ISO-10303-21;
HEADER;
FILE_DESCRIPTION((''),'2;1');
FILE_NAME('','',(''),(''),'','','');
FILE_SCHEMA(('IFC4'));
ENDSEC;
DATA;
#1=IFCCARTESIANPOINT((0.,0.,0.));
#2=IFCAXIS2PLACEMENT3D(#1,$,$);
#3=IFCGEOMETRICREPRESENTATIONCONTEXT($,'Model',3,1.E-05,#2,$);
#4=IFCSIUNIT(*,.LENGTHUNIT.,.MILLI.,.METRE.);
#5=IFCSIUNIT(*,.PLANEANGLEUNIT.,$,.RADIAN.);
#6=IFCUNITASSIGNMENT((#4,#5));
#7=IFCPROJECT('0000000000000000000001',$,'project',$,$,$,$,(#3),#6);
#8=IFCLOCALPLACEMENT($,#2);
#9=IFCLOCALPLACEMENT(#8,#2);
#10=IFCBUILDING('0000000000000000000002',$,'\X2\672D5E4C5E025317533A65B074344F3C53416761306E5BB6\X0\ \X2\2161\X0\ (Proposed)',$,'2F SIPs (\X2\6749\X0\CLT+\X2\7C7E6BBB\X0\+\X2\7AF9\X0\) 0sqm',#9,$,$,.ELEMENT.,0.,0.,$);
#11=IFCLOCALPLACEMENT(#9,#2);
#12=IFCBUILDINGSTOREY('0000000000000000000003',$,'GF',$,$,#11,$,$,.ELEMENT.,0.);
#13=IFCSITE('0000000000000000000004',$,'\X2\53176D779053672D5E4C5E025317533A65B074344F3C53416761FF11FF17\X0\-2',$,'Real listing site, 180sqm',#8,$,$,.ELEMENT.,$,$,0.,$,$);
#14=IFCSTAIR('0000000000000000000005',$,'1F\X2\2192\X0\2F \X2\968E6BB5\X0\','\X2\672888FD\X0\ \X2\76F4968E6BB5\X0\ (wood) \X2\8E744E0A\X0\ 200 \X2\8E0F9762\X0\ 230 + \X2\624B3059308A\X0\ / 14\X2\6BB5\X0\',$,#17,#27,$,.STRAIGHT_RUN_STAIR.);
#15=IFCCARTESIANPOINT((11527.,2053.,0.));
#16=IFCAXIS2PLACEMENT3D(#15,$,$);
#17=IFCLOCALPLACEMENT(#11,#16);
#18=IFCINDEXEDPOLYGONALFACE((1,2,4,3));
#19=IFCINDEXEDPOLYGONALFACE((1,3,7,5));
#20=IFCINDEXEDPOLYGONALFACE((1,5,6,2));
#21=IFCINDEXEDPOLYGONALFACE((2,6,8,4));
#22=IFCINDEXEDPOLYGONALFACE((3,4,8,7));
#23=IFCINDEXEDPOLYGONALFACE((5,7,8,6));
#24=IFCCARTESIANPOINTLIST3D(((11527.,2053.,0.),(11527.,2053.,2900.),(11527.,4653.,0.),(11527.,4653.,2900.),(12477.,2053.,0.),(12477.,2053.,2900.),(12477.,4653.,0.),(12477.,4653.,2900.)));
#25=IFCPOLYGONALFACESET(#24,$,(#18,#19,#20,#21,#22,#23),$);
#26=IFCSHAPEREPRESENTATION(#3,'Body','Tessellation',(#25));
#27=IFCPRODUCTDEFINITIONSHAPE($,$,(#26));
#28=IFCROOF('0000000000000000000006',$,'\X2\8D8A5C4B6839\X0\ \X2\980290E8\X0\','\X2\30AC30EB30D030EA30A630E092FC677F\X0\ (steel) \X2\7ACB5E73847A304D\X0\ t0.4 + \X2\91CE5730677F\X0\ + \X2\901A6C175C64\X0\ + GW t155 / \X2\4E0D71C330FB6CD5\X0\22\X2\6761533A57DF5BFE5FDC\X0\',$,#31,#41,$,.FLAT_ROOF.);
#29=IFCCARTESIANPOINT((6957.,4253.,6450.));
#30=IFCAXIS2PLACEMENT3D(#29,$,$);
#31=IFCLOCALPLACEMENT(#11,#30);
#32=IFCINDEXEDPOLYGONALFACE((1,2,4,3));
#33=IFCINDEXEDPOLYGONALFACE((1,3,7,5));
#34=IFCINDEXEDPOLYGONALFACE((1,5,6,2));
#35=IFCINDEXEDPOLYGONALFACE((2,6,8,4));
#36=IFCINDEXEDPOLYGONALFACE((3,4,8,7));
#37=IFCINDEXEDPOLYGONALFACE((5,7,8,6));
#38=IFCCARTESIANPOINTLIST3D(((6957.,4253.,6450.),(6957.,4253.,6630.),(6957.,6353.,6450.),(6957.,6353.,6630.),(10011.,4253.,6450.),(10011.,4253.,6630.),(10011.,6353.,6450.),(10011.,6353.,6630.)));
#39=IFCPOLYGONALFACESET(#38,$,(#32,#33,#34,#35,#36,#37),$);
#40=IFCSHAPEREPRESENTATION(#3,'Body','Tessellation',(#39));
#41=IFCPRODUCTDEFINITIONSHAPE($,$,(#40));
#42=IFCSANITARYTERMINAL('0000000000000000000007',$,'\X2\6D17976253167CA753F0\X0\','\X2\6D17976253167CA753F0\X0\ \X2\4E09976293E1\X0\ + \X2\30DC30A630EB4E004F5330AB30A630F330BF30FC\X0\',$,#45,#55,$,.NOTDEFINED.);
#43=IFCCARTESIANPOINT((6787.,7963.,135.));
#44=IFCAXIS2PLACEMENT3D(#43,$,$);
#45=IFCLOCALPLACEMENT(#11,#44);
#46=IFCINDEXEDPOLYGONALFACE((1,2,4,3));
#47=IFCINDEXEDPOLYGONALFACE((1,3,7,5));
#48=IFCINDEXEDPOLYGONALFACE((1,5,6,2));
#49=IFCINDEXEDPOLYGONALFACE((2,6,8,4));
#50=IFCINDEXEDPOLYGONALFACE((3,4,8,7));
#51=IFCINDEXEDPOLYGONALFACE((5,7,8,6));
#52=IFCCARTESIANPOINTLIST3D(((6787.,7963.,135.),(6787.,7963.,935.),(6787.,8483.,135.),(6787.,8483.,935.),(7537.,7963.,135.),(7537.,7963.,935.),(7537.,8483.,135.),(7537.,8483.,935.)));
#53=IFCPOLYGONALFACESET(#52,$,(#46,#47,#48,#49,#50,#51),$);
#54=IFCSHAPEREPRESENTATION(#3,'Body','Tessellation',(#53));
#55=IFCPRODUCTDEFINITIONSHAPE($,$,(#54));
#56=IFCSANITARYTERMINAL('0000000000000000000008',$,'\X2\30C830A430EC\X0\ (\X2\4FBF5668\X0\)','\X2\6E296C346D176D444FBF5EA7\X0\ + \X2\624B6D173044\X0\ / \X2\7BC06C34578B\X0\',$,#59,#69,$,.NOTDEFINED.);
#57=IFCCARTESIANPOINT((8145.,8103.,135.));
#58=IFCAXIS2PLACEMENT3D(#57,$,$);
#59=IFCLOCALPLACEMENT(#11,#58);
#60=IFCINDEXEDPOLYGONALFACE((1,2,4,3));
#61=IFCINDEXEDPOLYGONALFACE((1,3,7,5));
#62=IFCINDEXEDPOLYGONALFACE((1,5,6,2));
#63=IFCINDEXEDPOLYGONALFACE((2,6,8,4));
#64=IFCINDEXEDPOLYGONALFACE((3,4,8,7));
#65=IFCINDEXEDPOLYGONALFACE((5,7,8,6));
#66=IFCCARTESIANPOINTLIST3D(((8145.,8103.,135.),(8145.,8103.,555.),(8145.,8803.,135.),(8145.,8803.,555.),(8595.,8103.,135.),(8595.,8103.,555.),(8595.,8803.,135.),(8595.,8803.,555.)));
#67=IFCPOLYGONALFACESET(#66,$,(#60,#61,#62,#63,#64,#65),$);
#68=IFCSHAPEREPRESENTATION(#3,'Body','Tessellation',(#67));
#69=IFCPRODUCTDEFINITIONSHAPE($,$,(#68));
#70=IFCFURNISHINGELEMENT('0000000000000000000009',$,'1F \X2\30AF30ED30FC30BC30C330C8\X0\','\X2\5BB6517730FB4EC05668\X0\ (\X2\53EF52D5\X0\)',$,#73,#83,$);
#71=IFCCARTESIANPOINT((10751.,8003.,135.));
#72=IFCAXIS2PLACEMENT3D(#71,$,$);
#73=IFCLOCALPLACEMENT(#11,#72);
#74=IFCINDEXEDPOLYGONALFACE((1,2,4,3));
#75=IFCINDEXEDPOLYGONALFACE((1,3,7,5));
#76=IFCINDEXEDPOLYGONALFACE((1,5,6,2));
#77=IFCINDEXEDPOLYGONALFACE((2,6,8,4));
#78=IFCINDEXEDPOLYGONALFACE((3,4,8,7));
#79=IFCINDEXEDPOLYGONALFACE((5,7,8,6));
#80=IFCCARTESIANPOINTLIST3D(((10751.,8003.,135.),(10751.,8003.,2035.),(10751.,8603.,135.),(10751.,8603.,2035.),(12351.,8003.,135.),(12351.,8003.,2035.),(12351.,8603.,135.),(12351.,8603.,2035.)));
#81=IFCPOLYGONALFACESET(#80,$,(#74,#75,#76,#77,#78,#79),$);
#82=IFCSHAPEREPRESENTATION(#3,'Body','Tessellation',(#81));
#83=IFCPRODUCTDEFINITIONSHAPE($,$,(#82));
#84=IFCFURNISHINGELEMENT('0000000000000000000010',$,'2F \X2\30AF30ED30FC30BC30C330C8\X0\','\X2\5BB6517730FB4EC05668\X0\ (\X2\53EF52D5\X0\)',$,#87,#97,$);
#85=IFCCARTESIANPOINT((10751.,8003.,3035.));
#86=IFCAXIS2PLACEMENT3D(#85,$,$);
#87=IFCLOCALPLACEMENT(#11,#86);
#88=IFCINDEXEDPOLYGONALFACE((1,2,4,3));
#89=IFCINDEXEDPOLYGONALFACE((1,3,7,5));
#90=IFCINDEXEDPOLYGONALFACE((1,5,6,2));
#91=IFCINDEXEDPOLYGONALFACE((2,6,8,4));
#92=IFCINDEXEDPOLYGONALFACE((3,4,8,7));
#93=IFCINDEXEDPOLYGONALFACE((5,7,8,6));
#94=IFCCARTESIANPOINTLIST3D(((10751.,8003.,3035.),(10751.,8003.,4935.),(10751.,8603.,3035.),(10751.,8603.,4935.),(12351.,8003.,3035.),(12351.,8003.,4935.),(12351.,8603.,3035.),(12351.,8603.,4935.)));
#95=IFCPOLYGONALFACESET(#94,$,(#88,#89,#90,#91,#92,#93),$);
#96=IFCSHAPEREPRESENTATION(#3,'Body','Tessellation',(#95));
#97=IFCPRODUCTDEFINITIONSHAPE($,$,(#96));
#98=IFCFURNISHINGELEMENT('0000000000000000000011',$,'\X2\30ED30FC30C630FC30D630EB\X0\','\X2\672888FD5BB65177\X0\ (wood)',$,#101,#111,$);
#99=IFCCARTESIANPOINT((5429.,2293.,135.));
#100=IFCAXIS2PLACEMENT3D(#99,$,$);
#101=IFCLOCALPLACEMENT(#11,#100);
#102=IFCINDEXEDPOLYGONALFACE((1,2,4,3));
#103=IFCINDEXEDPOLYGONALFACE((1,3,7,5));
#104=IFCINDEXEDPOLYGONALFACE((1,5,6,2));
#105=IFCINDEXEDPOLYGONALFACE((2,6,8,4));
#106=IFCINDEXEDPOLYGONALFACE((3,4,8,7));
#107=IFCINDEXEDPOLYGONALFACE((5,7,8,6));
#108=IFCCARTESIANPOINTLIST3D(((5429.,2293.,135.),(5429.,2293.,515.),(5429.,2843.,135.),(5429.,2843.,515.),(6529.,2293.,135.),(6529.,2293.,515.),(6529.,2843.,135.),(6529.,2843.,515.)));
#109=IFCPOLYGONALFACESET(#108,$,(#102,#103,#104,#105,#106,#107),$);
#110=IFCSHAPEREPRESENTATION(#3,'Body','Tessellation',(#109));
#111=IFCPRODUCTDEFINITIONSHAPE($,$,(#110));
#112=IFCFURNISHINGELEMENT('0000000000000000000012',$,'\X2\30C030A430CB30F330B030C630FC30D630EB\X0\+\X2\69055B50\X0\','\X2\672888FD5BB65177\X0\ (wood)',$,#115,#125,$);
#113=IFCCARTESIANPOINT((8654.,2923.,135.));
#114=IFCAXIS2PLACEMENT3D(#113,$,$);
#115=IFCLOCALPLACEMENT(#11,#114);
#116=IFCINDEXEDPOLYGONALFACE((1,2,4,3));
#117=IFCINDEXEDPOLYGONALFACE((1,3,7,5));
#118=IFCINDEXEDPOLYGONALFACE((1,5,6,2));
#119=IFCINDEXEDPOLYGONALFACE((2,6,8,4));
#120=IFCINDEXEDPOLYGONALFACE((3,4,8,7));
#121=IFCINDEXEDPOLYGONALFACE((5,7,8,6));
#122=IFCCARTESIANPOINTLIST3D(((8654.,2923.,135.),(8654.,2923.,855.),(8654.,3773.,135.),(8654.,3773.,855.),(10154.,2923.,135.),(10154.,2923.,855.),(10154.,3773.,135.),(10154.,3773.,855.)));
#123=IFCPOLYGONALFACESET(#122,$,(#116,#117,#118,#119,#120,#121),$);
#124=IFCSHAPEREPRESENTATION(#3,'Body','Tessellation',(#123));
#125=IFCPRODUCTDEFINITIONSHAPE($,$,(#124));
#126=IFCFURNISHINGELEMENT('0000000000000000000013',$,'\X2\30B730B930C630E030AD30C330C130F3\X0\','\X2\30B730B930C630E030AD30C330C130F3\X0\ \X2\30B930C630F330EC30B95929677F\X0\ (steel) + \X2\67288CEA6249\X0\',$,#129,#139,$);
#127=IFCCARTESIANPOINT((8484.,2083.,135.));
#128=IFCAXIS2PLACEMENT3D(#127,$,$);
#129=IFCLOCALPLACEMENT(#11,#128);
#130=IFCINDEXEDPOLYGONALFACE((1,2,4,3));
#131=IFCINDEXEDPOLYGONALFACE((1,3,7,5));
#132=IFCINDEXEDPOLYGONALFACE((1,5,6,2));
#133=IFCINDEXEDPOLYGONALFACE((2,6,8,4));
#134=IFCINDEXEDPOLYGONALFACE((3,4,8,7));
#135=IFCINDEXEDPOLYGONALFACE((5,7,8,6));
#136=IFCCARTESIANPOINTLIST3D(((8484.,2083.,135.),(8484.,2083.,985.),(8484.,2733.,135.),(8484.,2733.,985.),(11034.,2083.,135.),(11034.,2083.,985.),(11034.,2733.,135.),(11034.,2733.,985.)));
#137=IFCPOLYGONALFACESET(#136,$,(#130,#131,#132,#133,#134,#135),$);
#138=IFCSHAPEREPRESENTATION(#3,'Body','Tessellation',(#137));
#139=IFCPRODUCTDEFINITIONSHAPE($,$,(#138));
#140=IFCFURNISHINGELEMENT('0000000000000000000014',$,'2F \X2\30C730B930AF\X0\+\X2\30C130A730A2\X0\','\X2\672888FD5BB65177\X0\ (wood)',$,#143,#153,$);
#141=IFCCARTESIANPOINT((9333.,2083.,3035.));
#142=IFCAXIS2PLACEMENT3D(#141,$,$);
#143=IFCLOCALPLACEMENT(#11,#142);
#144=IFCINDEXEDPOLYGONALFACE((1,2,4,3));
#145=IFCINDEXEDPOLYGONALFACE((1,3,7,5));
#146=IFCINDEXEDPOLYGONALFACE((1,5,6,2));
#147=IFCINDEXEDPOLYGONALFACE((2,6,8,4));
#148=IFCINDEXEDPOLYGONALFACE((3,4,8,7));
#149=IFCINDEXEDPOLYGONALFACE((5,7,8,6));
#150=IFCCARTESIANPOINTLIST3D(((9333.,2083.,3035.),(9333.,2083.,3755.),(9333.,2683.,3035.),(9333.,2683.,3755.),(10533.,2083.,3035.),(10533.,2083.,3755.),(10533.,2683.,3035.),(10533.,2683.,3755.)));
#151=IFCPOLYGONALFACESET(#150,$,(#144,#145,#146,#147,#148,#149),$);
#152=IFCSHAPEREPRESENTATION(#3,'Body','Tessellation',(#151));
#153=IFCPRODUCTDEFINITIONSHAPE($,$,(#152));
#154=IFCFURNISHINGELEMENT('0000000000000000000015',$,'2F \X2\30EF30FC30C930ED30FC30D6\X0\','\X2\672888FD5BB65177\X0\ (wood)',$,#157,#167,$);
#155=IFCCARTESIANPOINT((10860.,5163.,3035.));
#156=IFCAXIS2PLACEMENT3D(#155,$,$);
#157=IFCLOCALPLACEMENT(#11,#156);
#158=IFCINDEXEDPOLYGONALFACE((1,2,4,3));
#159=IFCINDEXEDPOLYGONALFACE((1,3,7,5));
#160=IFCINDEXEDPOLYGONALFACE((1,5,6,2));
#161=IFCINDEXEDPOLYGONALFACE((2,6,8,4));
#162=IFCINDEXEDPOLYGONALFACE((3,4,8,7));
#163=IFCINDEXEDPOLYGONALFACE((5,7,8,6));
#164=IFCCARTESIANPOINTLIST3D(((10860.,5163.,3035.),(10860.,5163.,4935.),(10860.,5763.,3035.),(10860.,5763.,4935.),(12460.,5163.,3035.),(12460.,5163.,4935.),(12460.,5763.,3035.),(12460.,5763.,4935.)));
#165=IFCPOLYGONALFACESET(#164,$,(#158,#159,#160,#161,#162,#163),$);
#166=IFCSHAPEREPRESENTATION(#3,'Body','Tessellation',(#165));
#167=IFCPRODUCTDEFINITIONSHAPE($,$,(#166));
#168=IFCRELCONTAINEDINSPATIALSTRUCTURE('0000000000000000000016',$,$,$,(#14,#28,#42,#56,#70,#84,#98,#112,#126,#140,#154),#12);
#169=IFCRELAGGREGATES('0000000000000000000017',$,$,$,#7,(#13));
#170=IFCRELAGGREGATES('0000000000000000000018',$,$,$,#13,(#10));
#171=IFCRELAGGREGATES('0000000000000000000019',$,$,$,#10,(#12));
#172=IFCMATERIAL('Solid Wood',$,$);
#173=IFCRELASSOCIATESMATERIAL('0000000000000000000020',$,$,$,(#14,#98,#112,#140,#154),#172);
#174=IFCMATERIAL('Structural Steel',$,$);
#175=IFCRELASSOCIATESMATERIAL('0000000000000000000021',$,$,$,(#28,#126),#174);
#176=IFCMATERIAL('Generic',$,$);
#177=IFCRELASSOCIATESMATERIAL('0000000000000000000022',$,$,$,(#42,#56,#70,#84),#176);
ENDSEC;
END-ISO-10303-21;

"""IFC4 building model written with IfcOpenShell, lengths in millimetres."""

from ifc_helpers import new_model, si_unit, frame, frame_2d, origin, place, context, project, spatial, rectangle, extrude, material, element, save


model = new_model("IFC4")

# Units and contexts
model_context = context("Model", 3, precision=1e-05, world=origin())
ifc_project = project(units=[si_unit("LENGTHUNIT", "METRE", prefix="MILLI"), si_unit("PLANEANGLEUNIT", "RADIAN")], contexts=[model_context])

# Site, building, storey
site_placement = place(None, origin())
site = spatial("IfcSite", under=ifc_project, at=site_placement, Name="北海道札幌市北区新琴似十条１７-2", ObjectType="Real listing site, 180sqm", CompositionType="ELEMENT", RefElevation=0.0)
building_placement = place(site_placement, origin())
building = spatial("IfcBuilding", under=site, at=building_placement, Name="札幌市北区新琴似十条の家 Ⅱ (Proposed)", ObjectType="2F SIPs (杉CLT+籾殻+竹) 0sqm", CompositionType="ELEMENT", ElevationOfRefHeight=0.0, ElevationOfTerrain=0.0)
storey_placement = place(building_placement, origin())
storey = spatial("IfcBuildingStorey", under=building, at=storey_placement, Name="GF", CompositionType="ELEMENT", Elevation=0.0)

# Shared definitions
ifc_material_1 = material(Name="Solid Wood")

# Stair
stair_placement = place(storey_placement, frame((11527.0, 2053.0, 0.0)))
element("IfcStair", 1, at=stair_placement, inside=storey, material=ifc_material_1, Name="1F→2F 階段", Description="木製 直階段 (wood) 蹴上 200 踏面 230 + 手すり / 14段", PredefinedType="STRAIGHT_RUN_STAIR", context=model_context, shape_type="SweptSolid", body=[
    extrude(rectangle(XDim=950.0, YDim=2600.0, at=frame_2d((475.0, 1300.0))), frame((11527.0, 2053.0, 0.0)), (0.0, 0.0, 1.0), 2900.0),
])

# Roof
ifc_material_2 = material(Name="Structural Steel")
roof_placement = place(storey_placement, frame((6957.0, 4253.0, 6450.0)))
element("IfcRoof", 2, at=roof_placement, inside=storey, material=ifc_material_2, Name="越屋根 頂部", Description="ガルバリウム鋼板 (steel) 立平葺き t0.4 + 野地板 + 通気層 + GW t155 / 不燃・法22条区域対応", PredefinedType="FLAT_ROOF", context=model_context, shape_type="SweptSolid", body=[
    extrude(rectangle(XDim=3054.0, YDim=2100.0, at=frame_2d((1527.0, 1050.0))), frame((6957.0, 4253.0, 6450.0)), (0.0, 0.0, 1.0), 180.0),
])

# Sanitary terminals
ifc_material_3 = material(Name="Generic")
sanitary_terminal_1_placement = place(storey_placement, frame((6787.0, 7963.0, 135.0)))
element("IfcSanitaryTerminal", 3, at=sanitary_terminal_1_placement, inside=storey, material=ifc_material_3, Name="洗面化粧台", Description="洗面化粧台 三面鏡 + ボウル一体カウンター", PredefinedType="NOTDEFINED", context=model_context, shape_type="SweptSolid", body=[
    extrude(rectangle(XDim=750.0, YDim=520.0, at=frame_2d((375.0, 260.0))), frame((6787.0, 7963.0, 135.0)), (0.0, 0.0, 1.0), 800.0),
])
sanitary_terminal_2_placement = place(storey_placement, frame((8145.0, 8103.0, 135.0)))
element("IfcSanitaryTerminal", 4, at=sanitary_terminal_2_placement, inside=storey, material=ifc_material_3, Name="トイレ (便器)", Description="温水洗浄便座 + 手洗い / 節水型", PredefinedType="NOTDEFINED", context=model_context, shape_type="SweptSolid", body=[
    extrude(rectangle(XDim=450.0, YDim=700.0, at=frame_2d((225.0, 350.0))), frame((8145.0, 8103.0, 135.0)), (0.0, 0.0, 1.0), 420.0),
])

# Furnishing elements
furnishing_1_placement = place(storey_placement, frame((10751.0, 8003.0, 135.0)))
element("IfcFurnishingElement", 5, at=furnishing_1_placement, inside=storey, material=ifc_material_3, Name="1F クローゼット", Description="家具・什器 (可動)", context=model_context, shape_type="SweptSolid", body=[
    extrude(rectangle(XDim=1600.0, YDim=600.0, at=frame_2d((800.0, 300.0))), frame((10751.0, 8003.0, 135.0)), (0.0, 0.0, 1.0), 1900.0),
])
furnishing_2_placement = place(storey_placement, frame((10751.0, 8003.0, 3035.0)))
element("IfcFurnishingElement", 6, at=furnishing_2_placement, inside=storey, material=ifc_material_3, Name="2F クローゼット", Description="家具・什器 (可動)", context=model_context, shape_type="SweptSolid", body=[
    extrude(rectangle(XDim=1600.0, YDim=600.0, at=frame_2d((800.0, 300.0))), frame((10751.0, 8003.0, 3035.0)), (0.0, 0.0, 1.0), 1900.0),
])
furnishing_3_placement = place(storey_placement, frame((5429.0, 2293.0, 135.0)))
element("IfcFurnishingElement", 7, at=furnishing_3_placement, inside=storey, material=ifc_material_1, Name="ローテーブル", Description="木製家具 (wood)", context=model_context, shape_type="SweptSolid", body=[
    extrude(rectangle(XDim=1100.0, YDim=550.0, at=frame_2d((550.0, 275.0))), frame((5429.0, 2293.0, 135.0)), (0.0, 0.0, 1.0), 380.0),
])
furnishing_4_placement = place(storey_placement, frame((8654.0, 2923.0, 135.0)))
element("IfcFurnishingElement", 8, at=furnishing_4_placement, inside=storey, material=ifc_material_1, Name="ダイニングテーブル+椅子", Description="木製家具 (wood)", context=model_context, shape_type="SweptSolid", body=[
    extrude(rectangle(XDim=1500.0, YDim=850.0, at=frame_2d((750.0, 425.0))), frame((8654.0, 2923.0, 135.0)), (0.0, 0.0, 1.0), 720.0),
])
furnishing_5_placement = place(storey_placement, frame((8484.0, 2083.0, 135.0)))
element("IfcFurnishingElement", 9, at=furnishing_5_placement, inside=storey, material=ifc_material_2, Name="システムキッチン", Description="システムキッチン ステンレス天板 (steel) + 木質扉", context=model_context, shape_type="SweptSolid", body=[
    extrude(rectangle(XDim=2550.0, YDim=650.0, at=frame_2d((1275.0, 325.0))), frame((8484.0, 2083.0, 135.0)), (0.0, 0.0, 1.0), 850.0),
])
furnishing_6_placement = place(storey_placement, frame((9333.0, 2083.0, 3035.0)))
element("IfcFurnishingElement", 10, at=furnishing_6_placement, inside=storey, material=ifc_material_1, Name="2F デスク+チェア", Description="木製家具 (wood)", context=model_context, shape_type="SweptSolid", body=[
    extrude(rectangle(XDim=1200.0, YDim=600.0, at=frame_2d((600.0, 300.0))), frame((9333.0, 2083.0, 3035.0)), (0.0, 0.0, 1.0), 720.0),
])
furnishing_7_placement = place(storey_placement, frame((10860.0, 5163.0, 3035.0)))
element("IfcFurnishingElement", 11, at=furnishing_7_placement, inside=storey, material=ifc_material_1, Name="2F ワードローブ", Description="木製家具 (wood)", context=model_context, shape_type="SweptSolid", body=[
    extrude(rectangle(XDim=1600.0, YDim=600.0, at=frame_2d((800.0, 300.0))), frame((10860.0, 5163.0, 3035.0)), (0.0, 0.0, 1.0), 1900.0),
])

save(model, "model.ifc")
